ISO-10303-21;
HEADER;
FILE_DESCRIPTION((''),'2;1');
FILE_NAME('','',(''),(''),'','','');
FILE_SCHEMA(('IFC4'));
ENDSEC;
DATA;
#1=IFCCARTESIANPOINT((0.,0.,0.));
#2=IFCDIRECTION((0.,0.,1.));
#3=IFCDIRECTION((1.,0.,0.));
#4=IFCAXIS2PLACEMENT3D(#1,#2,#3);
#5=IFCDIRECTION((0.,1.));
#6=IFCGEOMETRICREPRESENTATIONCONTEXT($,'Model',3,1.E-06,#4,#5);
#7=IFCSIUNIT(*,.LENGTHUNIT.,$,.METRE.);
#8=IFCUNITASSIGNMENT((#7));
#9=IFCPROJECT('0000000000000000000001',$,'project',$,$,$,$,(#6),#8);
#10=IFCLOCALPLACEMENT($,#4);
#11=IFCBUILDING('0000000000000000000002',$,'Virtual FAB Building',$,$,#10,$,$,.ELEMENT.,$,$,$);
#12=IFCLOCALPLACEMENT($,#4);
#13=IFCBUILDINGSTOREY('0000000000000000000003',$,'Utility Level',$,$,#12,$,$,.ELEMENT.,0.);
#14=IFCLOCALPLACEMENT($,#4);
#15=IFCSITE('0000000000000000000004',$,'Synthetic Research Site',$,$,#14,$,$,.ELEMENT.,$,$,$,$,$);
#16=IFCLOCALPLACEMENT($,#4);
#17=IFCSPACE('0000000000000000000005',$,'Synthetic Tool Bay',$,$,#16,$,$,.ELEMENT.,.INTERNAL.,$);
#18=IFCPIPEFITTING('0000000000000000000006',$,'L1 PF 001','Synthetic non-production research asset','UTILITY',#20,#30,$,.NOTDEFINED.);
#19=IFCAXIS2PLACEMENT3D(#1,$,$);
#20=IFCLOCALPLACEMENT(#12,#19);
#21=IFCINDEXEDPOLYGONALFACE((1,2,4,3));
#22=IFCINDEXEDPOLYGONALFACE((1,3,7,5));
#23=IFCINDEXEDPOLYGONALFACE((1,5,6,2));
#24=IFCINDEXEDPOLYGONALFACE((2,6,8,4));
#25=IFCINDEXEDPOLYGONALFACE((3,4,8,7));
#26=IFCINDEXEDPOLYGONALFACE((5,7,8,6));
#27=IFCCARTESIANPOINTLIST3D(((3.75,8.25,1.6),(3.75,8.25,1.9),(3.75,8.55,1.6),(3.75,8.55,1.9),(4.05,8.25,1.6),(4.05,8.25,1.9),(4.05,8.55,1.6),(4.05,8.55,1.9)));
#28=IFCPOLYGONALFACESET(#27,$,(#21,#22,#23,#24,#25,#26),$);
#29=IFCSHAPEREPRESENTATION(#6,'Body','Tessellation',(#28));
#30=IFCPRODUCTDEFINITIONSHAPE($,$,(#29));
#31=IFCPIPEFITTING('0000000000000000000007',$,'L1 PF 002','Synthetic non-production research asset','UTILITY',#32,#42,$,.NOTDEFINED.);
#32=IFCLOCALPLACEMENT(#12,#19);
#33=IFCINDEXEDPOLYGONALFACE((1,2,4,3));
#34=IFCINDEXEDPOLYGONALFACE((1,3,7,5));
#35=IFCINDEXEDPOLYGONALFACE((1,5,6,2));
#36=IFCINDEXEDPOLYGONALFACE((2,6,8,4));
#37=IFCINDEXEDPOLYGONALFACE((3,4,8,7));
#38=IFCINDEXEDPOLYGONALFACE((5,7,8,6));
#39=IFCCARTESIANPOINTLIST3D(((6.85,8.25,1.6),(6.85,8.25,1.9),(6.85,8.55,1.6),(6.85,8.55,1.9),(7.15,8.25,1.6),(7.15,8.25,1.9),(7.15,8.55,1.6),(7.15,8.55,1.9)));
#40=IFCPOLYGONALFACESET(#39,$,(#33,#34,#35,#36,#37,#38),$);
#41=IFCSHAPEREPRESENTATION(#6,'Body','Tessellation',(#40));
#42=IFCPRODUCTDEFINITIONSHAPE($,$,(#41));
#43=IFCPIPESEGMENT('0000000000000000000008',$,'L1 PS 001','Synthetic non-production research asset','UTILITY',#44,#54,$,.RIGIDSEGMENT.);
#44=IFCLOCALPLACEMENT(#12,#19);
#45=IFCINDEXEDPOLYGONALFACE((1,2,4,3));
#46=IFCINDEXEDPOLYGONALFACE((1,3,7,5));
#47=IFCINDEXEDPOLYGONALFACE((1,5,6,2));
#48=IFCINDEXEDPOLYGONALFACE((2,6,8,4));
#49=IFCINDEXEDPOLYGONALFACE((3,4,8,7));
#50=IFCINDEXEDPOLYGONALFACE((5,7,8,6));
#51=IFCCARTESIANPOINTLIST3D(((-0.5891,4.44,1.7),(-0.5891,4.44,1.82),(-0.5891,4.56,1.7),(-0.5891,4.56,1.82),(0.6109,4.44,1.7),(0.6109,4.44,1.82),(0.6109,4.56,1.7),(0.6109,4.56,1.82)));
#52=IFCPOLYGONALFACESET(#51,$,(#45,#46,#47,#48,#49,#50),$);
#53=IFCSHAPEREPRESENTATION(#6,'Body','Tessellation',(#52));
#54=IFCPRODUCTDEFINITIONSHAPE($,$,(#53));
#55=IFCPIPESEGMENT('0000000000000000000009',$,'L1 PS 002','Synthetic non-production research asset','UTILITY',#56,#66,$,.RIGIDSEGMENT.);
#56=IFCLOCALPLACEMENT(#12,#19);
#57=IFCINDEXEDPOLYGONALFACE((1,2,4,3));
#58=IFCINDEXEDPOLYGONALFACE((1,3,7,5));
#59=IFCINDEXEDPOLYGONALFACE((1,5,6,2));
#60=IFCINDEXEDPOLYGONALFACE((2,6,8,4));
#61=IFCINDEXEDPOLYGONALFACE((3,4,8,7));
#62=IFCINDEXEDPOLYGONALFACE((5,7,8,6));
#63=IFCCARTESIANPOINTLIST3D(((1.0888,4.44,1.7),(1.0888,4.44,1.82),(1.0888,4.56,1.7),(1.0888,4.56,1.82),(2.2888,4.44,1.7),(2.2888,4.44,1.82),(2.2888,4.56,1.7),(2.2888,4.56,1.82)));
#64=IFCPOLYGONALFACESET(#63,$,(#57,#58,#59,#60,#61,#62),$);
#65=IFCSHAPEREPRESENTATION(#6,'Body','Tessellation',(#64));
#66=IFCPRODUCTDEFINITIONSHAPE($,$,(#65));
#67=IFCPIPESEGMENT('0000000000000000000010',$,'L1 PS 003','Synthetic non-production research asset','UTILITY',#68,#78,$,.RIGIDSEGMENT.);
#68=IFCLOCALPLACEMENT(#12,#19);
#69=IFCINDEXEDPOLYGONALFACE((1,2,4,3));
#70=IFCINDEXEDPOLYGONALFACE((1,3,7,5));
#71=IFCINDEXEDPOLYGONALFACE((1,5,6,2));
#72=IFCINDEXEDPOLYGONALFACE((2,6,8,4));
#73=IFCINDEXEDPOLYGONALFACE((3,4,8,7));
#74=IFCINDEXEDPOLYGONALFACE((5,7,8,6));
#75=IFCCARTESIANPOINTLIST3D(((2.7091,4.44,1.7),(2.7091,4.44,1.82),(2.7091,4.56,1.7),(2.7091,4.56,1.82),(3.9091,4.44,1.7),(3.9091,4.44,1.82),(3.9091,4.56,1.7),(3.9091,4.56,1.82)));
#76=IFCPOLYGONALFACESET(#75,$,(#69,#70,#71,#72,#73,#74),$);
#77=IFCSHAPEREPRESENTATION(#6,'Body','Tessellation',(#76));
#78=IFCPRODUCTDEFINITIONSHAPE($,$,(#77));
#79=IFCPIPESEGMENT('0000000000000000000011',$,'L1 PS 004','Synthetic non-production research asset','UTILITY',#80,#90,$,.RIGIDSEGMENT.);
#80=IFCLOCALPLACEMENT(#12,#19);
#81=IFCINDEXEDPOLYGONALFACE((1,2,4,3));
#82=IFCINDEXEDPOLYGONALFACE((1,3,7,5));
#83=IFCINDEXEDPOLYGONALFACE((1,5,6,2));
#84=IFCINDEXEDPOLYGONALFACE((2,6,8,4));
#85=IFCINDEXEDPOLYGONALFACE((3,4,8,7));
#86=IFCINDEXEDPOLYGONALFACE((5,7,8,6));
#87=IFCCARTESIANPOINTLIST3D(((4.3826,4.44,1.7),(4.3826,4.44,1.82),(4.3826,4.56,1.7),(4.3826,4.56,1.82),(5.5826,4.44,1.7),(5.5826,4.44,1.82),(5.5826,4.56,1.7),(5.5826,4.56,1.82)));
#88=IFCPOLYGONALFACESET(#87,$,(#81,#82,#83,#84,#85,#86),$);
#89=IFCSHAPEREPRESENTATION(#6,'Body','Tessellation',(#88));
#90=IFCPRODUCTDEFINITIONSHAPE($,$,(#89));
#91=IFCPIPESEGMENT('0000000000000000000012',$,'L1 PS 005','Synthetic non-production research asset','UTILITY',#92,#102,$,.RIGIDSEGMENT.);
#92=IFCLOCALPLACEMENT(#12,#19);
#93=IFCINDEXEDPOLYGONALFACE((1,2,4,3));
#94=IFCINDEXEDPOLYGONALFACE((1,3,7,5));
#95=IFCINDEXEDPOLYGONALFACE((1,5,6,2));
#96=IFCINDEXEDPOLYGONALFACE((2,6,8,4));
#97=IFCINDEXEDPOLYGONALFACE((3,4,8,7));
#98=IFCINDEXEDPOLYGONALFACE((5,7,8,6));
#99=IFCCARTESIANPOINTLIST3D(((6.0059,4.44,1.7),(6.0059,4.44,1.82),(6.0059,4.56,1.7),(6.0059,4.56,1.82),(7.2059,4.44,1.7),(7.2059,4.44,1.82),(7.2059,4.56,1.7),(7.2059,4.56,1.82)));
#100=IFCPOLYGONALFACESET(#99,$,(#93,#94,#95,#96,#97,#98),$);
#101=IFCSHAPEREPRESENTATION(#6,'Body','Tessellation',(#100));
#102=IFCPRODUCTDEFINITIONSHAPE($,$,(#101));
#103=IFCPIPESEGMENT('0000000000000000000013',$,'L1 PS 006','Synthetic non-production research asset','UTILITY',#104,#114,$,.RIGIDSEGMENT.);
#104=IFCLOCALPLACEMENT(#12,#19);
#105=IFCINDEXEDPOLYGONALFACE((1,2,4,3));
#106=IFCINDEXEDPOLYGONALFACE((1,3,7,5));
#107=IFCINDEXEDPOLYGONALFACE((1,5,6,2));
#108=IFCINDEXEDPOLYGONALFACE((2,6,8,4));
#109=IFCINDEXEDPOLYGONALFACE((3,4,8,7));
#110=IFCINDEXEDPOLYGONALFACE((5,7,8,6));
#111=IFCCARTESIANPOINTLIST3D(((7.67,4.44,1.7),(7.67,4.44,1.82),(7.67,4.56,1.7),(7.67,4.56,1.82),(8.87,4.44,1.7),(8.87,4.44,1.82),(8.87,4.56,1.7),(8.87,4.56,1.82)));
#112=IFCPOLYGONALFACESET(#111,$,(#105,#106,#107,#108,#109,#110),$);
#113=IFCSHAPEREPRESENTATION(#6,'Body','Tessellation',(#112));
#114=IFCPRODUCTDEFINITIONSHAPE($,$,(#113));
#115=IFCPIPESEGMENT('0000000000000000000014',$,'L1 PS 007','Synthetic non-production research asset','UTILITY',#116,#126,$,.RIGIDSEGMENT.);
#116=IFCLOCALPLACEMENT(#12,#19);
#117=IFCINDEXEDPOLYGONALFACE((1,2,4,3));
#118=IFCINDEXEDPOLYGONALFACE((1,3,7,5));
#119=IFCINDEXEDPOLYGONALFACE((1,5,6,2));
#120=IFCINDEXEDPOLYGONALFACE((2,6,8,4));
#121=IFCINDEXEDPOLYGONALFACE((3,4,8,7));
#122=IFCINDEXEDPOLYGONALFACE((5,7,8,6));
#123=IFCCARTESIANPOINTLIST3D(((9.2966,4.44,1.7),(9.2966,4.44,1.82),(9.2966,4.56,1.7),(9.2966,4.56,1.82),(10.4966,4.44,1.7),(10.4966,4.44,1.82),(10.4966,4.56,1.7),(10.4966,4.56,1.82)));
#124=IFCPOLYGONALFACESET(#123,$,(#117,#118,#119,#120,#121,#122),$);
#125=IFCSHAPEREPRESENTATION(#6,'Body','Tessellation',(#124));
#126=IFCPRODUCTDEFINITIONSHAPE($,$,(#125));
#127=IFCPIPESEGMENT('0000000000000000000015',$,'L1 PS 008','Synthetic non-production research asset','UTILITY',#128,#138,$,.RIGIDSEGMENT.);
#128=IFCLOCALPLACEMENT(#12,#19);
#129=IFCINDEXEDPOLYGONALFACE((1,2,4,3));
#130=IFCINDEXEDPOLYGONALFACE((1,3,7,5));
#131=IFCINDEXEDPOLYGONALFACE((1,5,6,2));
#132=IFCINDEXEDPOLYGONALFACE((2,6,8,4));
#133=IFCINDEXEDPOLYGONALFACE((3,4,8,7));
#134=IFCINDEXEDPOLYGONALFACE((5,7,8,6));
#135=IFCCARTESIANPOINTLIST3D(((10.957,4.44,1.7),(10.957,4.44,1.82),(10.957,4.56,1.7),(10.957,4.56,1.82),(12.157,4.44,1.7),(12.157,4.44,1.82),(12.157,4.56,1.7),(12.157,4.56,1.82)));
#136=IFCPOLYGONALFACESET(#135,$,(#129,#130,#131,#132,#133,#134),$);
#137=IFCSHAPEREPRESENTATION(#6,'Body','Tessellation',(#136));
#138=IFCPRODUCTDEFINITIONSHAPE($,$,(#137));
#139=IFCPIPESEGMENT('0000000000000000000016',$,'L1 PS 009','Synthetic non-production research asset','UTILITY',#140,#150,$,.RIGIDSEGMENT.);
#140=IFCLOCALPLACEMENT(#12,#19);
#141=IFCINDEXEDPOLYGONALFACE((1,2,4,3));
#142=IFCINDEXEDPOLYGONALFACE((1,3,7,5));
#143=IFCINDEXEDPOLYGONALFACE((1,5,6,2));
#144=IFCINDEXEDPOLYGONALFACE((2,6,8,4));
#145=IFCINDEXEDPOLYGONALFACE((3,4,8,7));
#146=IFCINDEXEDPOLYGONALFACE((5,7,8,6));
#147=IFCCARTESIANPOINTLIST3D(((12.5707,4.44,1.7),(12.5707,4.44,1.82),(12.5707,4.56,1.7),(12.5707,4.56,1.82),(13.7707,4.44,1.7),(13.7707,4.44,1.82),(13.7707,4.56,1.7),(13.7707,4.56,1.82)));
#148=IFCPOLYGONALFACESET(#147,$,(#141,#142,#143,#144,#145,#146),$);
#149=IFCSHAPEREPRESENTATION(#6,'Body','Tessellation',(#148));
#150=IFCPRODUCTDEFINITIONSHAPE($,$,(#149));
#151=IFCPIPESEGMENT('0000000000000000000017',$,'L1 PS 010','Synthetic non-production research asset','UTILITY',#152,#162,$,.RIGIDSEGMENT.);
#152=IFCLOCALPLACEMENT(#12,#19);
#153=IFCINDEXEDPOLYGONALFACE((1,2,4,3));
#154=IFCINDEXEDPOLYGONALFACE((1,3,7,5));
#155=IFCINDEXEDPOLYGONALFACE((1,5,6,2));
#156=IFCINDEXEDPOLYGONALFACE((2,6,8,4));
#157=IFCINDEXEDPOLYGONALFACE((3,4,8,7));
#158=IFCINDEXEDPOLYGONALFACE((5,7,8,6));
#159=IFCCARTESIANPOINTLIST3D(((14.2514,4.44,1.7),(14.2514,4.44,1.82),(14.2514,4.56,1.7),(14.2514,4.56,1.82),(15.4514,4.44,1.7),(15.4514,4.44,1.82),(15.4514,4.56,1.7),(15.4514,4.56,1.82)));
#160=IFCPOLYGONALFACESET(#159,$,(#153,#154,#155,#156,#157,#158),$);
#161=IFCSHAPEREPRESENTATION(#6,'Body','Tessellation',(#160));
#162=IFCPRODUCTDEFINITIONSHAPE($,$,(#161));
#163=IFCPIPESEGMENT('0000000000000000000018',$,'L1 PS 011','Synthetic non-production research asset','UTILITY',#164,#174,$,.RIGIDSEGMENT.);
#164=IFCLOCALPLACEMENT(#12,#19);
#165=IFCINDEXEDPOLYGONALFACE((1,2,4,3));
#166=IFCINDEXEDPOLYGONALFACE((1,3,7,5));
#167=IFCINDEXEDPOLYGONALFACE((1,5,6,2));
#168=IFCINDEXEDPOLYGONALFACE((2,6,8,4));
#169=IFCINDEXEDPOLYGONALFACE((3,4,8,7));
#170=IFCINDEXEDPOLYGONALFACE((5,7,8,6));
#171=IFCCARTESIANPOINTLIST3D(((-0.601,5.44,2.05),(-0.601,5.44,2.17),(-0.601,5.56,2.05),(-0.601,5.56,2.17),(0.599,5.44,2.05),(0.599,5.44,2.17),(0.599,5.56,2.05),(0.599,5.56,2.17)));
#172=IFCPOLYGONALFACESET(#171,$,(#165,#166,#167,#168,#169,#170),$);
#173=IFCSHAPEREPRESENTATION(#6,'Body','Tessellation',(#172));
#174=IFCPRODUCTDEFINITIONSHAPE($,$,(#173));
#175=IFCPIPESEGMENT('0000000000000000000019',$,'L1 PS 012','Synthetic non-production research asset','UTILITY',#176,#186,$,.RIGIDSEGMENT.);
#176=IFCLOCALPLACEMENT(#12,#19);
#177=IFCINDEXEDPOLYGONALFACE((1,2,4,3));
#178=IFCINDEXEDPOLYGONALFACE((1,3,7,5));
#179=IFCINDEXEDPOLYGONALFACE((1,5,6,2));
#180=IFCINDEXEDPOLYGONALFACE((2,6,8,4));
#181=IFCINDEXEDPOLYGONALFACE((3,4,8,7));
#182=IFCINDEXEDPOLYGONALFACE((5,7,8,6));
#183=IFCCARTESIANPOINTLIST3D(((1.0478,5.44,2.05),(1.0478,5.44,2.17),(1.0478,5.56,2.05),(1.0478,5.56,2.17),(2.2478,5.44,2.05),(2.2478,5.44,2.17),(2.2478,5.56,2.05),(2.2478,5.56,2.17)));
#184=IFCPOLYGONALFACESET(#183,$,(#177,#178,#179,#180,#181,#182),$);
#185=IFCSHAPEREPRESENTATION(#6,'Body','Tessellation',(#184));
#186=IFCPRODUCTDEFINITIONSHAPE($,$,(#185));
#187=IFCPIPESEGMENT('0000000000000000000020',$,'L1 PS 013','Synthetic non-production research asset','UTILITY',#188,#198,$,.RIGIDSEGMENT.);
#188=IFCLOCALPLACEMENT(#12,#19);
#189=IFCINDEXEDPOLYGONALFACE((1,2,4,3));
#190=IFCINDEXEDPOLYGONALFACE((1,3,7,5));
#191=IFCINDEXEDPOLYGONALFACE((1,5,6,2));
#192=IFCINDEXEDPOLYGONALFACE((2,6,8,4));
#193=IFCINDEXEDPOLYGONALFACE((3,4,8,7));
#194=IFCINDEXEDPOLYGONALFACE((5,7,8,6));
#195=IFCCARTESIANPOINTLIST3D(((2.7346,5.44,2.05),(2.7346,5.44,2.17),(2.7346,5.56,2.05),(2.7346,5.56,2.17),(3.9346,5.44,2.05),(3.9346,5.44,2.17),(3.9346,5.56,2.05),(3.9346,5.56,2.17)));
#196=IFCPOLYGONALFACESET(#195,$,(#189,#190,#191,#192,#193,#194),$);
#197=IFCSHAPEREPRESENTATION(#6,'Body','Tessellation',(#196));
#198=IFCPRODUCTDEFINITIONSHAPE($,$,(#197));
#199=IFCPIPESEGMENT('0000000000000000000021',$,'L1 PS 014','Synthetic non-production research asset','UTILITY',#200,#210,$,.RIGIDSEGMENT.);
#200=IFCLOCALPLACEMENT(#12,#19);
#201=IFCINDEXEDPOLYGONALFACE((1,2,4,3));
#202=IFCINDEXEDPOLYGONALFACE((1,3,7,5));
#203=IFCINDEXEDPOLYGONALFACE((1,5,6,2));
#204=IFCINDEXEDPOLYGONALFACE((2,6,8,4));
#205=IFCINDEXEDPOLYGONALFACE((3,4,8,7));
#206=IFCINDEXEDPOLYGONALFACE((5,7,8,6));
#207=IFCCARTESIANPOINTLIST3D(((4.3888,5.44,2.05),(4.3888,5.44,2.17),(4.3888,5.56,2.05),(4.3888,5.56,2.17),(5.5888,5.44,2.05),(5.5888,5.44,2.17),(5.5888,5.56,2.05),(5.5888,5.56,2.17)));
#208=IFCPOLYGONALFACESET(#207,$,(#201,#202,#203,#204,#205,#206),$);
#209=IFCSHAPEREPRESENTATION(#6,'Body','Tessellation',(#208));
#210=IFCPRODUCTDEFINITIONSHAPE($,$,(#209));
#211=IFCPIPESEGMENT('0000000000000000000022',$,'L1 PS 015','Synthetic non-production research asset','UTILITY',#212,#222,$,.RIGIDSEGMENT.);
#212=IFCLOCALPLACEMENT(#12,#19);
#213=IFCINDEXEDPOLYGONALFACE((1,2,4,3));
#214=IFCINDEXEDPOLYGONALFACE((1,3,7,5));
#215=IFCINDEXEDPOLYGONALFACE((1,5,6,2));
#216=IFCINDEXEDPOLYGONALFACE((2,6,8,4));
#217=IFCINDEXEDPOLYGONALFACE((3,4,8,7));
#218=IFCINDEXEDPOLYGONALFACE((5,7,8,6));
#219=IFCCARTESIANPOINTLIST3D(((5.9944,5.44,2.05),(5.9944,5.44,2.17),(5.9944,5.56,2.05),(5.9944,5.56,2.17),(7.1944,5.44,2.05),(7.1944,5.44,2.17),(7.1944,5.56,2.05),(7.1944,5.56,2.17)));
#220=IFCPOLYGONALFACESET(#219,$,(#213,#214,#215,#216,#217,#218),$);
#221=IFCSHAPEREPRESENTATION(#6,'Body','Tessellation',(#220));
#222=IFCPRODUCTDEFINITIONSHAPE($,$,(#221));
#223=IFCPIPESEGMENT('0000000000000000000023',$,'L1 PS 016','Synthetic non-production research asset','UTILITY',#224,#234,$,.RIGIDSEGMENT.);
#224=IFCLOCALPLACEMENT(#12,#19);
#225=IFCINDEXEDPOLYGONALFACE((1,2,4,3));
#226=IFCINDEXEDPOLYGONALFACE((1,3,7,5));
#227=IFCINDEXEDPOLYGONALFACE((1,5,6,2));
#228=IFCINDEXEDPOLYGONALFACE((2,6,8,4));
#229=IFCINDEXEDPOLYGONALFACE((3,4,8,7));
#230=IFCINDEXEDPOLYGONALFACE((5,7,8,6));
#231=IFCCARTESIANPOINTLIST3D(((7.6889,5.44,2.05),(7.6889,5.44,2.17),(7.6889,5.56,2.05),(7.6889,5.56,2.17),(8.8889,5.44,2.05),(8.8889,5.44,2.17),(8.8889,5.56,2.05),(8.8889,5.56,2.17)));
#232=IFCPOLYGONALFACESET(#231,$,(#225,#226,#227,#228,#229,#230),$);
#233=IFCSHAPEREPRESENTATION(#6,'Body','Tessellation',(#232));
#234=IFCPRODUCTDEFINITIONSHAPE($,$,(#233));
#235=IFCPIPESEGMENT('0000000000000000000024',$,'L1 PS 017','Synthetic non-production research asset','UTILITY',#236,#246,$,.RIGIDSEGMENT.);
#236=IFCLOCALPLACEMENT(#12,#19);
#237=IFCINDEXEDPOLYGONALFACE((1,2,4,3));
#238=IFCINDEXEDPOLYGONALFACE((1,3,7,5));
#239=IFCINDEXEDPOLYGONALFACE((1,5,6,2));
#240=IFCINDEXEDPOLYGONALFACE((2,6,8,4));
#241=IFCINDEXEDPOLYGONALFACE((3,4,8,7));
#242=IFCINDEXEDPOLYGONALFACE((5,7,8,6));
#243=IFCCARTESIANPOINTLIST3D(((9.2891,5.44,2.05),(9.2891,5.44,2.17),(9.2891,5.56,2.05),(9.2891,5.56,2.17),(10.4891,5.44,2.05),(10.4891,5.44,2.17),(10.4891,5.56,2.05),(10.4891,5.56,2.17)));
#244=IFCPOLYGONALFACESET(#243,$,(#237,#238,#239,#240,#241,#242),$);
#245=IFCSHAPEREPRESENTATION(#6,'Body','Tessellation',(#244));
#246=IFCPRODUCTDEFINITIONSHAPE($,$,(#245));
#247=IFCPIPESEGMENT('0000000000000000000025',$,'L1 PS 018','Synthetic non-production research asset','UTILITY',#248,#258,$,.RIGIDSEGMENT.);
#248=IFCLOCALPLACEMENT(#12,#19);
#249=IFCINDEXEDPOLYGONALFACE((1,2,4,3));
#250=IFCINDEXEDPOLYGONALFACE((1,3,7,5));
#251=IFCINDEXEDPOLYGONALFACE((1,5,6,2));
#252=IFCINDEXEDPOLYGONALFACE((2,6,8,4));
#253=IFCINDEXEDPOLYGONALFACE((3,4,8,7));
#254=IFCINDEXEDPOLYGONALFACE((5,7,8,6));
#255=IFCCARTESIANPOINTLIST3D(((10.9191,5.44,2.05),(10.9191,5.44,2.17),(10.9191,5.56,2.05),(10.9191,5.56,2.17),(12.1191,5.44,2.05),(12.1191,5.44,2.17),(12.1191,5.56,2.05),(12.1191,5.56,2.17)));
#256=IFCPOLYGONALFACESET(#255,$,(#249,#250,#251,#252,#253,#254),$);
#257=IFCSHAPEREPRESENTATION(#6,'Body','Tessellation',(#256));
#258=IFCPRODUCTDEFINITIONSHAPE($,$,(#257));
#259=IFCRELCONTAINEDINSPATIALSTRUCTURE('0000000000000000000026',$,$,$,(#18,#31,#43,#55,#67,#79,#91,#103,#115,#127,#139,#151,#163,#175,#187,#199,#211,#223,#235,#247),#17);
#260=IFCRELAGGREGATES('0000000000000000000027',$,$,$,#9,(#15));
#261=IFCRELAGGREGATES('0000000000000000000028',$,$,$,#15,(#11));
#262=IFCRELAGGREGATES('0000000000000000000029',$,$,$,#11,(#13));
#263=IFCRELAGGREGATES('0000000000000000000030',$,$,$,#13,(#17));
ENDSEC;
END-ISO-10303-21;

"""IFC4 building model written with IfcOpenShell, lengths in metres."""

from ifc_helpers import new_model, si_unit, direction, frame, origin_with_axes, origin_2d_with_axis, place, context, project, spatial, rectangle, extrude, element, save


model = new_model("IFC4")

# Units and contexts
model_context = context("Model", 3, precision=1e-06, world=origin_with_axes(), true_north=direction((0.0, 1.0)))
ifc_project = project(units=[si_unit("LENGTHUNIT", "METRE")], contexts=[model_context])

# Site, building, storey, space
site_placement = place(None, origin_with_axes())
site = spatial("IfcSite", under=ifc_project, at=site_placement, Name="Synthetic Research Site", CompositionType="ELEMENT")
building_placement = place(None, origin_with_axes())
building = spatial("IfcBuilding", under=site, at=building_placement, Name="Virtual FAB Building", CompositionType="ELEMENT")
storey_placement = place(None, origin_with_axes())
storey = spatial("IfcBuildingStorey", under=building, at=storey_placement, Name="Utility Level", CompositionType="ELEMENT", Elevation=0.0)
space_placement = place(None, origin_with_axes())
space = spatial("IfcSpace", under=storey, at=space_placement, Name="Synthetic Tool Bay", CompositionType="ELEMENT", PredefinedType="INTERNAL")

# Pipe fittings
for number, where, z_axis, x_axis, name in (
    (1, (3.9, 8.4, 1.6), (0.0, 0.0, 1.0), (1.0, 0.0, 0.0), "L1 PF 001"),
    (2, (7.0, 8.4, 1.6), (0.0, 0.0, 1.0), (1.0, 0.0, 0.0), "L1 PF 002"),
):
    element("IfcPipeFitting", number, at=place(None, frame(where, z_axis=z_axis, x_axis=x_axis)), inside=space, Name=name, Description="Synthetic non-production research asset", ObjectType="UTILITY", PredefinedType="NOTDEFINED", context=model_context, shape_type="SweptSolid", body=[
        extrude(rectangle(XDim=0.3, YDim=0.3, at=origin_2d_with_axis()), origin_with_axes(), (0.0, 0.0, 1.0), 0.3),
    ])

# Pipe segments
for number, where, z_axis, x_axis, name in (
    (3, (0.0109, 4.5, 1.7), (0.0, 0.0, 1.0), (1.0, 0.0, 0.0), "L1 PS 001"),
    (4, (1.6888, 4.5, 1.7), (0.0, 0.0, 1.0), (1.0, 0.0, 0.0), "L1 PS 002"),
    (5, (3.3091, 4.5, 1.7), (0.0, 0.0, 1.0), (1.0, 0.0, 0.0), "L1 PS 003"),
    (6, (4.9826, 4.5, 1.7), (0.0, 0.0, 1.0), (1.0, 0.0, 0.0), "L1 PS 004"),
    (7, (6.6059, 4.5, 1.7), (0.0, 0.0, 1.0), (1.0, 0.0, 0.0), "L1 PS 005"),
    (8, (8.27, 4.5, 1.7), (0.0, 0.0, 1.0), (1.0, 0.0, 0.0), "L1 PS 006"),
    (9, (9.8966, 4.5, 1.7), (0.0, 0.0, 1.0), (1.0, 0.0, 0.0), "L1 PS 007"),
    (10, (11.557, 4.5, 1.7), (0.0, 0.0, 1.0), (1.0, 0.0, 0.0), "L1 PS 008"),
    (11, (13.1707, 4.5, 1.7), (0.0, 0.0, 1.0), (1.0, 0.0, 0.0), "L1 PS 009"),
    (12, (14.8514, 4.5, 1.7), (0.0, 0.0, 1.0), (1.0, 0.0, 0.0), "L1 PS 010"),
    (13, (-0.001, 5.5, 2.05), (0.0, 0.0, 1.0), (1.0, 0.0, 0.0), "L1 PS 011"),
    (14, (1.6478, 5.5, 2.05), (0.0, 0.0, 1.0), (1.0, 0.0, 0.0), "L1 PS 012"),
    (15, (3.3346, 5.5, 2.05), (0.0, 0.0, 1.0), (1.0, 0.0, 0.0), "L1 PS 013"),
    (16, (4.9888, 5.5, 2.05), (0.0, 0.0, 1.0), (1.0, 0.0, 0.0), "L1 PS 014"),
    (17, (6.5944, 5.5, 2.05), (0.0, 0.0, 1.0), (1.0, 0.0, 0.0), "L1 PS 015"),
    (18, (8.2889, 5.5, 2.05), (0.0, 0.0, 1.0), (1.0, 0.0, 0.0), "L1 PS 016"),
    (19, (9.8891, 5.5, 2.05), (0.0, 0.0, 1.0), (1.0, 0.0, 0.0), "L1 PS 017"),
    (20, (11.5191, 5.5, 2.05), (0.0, 0.0, 1.0), (1.0, 0.0, 0.0), "L1 PS 018"),
):
    element("IfcPipeSegment", number, at=place(None, frame(where, z_axis=z_axis, x_axis=x_axis)), inside=space, Name=name, Description="Synthetic non-production research asset", ObjectType="UTILITY", PredefinedType="RIGIDSEGMENT", context=model_context, shape_type="SweptSolid", body=[
        extrude(rectangle(XDim=1.2, YDim=0.12, at=origin_2d_with_axis()), origin_with_axes(), (0.0, 0.0, 1.0), 0.12),
    ])

save(model, "model.ifc")
